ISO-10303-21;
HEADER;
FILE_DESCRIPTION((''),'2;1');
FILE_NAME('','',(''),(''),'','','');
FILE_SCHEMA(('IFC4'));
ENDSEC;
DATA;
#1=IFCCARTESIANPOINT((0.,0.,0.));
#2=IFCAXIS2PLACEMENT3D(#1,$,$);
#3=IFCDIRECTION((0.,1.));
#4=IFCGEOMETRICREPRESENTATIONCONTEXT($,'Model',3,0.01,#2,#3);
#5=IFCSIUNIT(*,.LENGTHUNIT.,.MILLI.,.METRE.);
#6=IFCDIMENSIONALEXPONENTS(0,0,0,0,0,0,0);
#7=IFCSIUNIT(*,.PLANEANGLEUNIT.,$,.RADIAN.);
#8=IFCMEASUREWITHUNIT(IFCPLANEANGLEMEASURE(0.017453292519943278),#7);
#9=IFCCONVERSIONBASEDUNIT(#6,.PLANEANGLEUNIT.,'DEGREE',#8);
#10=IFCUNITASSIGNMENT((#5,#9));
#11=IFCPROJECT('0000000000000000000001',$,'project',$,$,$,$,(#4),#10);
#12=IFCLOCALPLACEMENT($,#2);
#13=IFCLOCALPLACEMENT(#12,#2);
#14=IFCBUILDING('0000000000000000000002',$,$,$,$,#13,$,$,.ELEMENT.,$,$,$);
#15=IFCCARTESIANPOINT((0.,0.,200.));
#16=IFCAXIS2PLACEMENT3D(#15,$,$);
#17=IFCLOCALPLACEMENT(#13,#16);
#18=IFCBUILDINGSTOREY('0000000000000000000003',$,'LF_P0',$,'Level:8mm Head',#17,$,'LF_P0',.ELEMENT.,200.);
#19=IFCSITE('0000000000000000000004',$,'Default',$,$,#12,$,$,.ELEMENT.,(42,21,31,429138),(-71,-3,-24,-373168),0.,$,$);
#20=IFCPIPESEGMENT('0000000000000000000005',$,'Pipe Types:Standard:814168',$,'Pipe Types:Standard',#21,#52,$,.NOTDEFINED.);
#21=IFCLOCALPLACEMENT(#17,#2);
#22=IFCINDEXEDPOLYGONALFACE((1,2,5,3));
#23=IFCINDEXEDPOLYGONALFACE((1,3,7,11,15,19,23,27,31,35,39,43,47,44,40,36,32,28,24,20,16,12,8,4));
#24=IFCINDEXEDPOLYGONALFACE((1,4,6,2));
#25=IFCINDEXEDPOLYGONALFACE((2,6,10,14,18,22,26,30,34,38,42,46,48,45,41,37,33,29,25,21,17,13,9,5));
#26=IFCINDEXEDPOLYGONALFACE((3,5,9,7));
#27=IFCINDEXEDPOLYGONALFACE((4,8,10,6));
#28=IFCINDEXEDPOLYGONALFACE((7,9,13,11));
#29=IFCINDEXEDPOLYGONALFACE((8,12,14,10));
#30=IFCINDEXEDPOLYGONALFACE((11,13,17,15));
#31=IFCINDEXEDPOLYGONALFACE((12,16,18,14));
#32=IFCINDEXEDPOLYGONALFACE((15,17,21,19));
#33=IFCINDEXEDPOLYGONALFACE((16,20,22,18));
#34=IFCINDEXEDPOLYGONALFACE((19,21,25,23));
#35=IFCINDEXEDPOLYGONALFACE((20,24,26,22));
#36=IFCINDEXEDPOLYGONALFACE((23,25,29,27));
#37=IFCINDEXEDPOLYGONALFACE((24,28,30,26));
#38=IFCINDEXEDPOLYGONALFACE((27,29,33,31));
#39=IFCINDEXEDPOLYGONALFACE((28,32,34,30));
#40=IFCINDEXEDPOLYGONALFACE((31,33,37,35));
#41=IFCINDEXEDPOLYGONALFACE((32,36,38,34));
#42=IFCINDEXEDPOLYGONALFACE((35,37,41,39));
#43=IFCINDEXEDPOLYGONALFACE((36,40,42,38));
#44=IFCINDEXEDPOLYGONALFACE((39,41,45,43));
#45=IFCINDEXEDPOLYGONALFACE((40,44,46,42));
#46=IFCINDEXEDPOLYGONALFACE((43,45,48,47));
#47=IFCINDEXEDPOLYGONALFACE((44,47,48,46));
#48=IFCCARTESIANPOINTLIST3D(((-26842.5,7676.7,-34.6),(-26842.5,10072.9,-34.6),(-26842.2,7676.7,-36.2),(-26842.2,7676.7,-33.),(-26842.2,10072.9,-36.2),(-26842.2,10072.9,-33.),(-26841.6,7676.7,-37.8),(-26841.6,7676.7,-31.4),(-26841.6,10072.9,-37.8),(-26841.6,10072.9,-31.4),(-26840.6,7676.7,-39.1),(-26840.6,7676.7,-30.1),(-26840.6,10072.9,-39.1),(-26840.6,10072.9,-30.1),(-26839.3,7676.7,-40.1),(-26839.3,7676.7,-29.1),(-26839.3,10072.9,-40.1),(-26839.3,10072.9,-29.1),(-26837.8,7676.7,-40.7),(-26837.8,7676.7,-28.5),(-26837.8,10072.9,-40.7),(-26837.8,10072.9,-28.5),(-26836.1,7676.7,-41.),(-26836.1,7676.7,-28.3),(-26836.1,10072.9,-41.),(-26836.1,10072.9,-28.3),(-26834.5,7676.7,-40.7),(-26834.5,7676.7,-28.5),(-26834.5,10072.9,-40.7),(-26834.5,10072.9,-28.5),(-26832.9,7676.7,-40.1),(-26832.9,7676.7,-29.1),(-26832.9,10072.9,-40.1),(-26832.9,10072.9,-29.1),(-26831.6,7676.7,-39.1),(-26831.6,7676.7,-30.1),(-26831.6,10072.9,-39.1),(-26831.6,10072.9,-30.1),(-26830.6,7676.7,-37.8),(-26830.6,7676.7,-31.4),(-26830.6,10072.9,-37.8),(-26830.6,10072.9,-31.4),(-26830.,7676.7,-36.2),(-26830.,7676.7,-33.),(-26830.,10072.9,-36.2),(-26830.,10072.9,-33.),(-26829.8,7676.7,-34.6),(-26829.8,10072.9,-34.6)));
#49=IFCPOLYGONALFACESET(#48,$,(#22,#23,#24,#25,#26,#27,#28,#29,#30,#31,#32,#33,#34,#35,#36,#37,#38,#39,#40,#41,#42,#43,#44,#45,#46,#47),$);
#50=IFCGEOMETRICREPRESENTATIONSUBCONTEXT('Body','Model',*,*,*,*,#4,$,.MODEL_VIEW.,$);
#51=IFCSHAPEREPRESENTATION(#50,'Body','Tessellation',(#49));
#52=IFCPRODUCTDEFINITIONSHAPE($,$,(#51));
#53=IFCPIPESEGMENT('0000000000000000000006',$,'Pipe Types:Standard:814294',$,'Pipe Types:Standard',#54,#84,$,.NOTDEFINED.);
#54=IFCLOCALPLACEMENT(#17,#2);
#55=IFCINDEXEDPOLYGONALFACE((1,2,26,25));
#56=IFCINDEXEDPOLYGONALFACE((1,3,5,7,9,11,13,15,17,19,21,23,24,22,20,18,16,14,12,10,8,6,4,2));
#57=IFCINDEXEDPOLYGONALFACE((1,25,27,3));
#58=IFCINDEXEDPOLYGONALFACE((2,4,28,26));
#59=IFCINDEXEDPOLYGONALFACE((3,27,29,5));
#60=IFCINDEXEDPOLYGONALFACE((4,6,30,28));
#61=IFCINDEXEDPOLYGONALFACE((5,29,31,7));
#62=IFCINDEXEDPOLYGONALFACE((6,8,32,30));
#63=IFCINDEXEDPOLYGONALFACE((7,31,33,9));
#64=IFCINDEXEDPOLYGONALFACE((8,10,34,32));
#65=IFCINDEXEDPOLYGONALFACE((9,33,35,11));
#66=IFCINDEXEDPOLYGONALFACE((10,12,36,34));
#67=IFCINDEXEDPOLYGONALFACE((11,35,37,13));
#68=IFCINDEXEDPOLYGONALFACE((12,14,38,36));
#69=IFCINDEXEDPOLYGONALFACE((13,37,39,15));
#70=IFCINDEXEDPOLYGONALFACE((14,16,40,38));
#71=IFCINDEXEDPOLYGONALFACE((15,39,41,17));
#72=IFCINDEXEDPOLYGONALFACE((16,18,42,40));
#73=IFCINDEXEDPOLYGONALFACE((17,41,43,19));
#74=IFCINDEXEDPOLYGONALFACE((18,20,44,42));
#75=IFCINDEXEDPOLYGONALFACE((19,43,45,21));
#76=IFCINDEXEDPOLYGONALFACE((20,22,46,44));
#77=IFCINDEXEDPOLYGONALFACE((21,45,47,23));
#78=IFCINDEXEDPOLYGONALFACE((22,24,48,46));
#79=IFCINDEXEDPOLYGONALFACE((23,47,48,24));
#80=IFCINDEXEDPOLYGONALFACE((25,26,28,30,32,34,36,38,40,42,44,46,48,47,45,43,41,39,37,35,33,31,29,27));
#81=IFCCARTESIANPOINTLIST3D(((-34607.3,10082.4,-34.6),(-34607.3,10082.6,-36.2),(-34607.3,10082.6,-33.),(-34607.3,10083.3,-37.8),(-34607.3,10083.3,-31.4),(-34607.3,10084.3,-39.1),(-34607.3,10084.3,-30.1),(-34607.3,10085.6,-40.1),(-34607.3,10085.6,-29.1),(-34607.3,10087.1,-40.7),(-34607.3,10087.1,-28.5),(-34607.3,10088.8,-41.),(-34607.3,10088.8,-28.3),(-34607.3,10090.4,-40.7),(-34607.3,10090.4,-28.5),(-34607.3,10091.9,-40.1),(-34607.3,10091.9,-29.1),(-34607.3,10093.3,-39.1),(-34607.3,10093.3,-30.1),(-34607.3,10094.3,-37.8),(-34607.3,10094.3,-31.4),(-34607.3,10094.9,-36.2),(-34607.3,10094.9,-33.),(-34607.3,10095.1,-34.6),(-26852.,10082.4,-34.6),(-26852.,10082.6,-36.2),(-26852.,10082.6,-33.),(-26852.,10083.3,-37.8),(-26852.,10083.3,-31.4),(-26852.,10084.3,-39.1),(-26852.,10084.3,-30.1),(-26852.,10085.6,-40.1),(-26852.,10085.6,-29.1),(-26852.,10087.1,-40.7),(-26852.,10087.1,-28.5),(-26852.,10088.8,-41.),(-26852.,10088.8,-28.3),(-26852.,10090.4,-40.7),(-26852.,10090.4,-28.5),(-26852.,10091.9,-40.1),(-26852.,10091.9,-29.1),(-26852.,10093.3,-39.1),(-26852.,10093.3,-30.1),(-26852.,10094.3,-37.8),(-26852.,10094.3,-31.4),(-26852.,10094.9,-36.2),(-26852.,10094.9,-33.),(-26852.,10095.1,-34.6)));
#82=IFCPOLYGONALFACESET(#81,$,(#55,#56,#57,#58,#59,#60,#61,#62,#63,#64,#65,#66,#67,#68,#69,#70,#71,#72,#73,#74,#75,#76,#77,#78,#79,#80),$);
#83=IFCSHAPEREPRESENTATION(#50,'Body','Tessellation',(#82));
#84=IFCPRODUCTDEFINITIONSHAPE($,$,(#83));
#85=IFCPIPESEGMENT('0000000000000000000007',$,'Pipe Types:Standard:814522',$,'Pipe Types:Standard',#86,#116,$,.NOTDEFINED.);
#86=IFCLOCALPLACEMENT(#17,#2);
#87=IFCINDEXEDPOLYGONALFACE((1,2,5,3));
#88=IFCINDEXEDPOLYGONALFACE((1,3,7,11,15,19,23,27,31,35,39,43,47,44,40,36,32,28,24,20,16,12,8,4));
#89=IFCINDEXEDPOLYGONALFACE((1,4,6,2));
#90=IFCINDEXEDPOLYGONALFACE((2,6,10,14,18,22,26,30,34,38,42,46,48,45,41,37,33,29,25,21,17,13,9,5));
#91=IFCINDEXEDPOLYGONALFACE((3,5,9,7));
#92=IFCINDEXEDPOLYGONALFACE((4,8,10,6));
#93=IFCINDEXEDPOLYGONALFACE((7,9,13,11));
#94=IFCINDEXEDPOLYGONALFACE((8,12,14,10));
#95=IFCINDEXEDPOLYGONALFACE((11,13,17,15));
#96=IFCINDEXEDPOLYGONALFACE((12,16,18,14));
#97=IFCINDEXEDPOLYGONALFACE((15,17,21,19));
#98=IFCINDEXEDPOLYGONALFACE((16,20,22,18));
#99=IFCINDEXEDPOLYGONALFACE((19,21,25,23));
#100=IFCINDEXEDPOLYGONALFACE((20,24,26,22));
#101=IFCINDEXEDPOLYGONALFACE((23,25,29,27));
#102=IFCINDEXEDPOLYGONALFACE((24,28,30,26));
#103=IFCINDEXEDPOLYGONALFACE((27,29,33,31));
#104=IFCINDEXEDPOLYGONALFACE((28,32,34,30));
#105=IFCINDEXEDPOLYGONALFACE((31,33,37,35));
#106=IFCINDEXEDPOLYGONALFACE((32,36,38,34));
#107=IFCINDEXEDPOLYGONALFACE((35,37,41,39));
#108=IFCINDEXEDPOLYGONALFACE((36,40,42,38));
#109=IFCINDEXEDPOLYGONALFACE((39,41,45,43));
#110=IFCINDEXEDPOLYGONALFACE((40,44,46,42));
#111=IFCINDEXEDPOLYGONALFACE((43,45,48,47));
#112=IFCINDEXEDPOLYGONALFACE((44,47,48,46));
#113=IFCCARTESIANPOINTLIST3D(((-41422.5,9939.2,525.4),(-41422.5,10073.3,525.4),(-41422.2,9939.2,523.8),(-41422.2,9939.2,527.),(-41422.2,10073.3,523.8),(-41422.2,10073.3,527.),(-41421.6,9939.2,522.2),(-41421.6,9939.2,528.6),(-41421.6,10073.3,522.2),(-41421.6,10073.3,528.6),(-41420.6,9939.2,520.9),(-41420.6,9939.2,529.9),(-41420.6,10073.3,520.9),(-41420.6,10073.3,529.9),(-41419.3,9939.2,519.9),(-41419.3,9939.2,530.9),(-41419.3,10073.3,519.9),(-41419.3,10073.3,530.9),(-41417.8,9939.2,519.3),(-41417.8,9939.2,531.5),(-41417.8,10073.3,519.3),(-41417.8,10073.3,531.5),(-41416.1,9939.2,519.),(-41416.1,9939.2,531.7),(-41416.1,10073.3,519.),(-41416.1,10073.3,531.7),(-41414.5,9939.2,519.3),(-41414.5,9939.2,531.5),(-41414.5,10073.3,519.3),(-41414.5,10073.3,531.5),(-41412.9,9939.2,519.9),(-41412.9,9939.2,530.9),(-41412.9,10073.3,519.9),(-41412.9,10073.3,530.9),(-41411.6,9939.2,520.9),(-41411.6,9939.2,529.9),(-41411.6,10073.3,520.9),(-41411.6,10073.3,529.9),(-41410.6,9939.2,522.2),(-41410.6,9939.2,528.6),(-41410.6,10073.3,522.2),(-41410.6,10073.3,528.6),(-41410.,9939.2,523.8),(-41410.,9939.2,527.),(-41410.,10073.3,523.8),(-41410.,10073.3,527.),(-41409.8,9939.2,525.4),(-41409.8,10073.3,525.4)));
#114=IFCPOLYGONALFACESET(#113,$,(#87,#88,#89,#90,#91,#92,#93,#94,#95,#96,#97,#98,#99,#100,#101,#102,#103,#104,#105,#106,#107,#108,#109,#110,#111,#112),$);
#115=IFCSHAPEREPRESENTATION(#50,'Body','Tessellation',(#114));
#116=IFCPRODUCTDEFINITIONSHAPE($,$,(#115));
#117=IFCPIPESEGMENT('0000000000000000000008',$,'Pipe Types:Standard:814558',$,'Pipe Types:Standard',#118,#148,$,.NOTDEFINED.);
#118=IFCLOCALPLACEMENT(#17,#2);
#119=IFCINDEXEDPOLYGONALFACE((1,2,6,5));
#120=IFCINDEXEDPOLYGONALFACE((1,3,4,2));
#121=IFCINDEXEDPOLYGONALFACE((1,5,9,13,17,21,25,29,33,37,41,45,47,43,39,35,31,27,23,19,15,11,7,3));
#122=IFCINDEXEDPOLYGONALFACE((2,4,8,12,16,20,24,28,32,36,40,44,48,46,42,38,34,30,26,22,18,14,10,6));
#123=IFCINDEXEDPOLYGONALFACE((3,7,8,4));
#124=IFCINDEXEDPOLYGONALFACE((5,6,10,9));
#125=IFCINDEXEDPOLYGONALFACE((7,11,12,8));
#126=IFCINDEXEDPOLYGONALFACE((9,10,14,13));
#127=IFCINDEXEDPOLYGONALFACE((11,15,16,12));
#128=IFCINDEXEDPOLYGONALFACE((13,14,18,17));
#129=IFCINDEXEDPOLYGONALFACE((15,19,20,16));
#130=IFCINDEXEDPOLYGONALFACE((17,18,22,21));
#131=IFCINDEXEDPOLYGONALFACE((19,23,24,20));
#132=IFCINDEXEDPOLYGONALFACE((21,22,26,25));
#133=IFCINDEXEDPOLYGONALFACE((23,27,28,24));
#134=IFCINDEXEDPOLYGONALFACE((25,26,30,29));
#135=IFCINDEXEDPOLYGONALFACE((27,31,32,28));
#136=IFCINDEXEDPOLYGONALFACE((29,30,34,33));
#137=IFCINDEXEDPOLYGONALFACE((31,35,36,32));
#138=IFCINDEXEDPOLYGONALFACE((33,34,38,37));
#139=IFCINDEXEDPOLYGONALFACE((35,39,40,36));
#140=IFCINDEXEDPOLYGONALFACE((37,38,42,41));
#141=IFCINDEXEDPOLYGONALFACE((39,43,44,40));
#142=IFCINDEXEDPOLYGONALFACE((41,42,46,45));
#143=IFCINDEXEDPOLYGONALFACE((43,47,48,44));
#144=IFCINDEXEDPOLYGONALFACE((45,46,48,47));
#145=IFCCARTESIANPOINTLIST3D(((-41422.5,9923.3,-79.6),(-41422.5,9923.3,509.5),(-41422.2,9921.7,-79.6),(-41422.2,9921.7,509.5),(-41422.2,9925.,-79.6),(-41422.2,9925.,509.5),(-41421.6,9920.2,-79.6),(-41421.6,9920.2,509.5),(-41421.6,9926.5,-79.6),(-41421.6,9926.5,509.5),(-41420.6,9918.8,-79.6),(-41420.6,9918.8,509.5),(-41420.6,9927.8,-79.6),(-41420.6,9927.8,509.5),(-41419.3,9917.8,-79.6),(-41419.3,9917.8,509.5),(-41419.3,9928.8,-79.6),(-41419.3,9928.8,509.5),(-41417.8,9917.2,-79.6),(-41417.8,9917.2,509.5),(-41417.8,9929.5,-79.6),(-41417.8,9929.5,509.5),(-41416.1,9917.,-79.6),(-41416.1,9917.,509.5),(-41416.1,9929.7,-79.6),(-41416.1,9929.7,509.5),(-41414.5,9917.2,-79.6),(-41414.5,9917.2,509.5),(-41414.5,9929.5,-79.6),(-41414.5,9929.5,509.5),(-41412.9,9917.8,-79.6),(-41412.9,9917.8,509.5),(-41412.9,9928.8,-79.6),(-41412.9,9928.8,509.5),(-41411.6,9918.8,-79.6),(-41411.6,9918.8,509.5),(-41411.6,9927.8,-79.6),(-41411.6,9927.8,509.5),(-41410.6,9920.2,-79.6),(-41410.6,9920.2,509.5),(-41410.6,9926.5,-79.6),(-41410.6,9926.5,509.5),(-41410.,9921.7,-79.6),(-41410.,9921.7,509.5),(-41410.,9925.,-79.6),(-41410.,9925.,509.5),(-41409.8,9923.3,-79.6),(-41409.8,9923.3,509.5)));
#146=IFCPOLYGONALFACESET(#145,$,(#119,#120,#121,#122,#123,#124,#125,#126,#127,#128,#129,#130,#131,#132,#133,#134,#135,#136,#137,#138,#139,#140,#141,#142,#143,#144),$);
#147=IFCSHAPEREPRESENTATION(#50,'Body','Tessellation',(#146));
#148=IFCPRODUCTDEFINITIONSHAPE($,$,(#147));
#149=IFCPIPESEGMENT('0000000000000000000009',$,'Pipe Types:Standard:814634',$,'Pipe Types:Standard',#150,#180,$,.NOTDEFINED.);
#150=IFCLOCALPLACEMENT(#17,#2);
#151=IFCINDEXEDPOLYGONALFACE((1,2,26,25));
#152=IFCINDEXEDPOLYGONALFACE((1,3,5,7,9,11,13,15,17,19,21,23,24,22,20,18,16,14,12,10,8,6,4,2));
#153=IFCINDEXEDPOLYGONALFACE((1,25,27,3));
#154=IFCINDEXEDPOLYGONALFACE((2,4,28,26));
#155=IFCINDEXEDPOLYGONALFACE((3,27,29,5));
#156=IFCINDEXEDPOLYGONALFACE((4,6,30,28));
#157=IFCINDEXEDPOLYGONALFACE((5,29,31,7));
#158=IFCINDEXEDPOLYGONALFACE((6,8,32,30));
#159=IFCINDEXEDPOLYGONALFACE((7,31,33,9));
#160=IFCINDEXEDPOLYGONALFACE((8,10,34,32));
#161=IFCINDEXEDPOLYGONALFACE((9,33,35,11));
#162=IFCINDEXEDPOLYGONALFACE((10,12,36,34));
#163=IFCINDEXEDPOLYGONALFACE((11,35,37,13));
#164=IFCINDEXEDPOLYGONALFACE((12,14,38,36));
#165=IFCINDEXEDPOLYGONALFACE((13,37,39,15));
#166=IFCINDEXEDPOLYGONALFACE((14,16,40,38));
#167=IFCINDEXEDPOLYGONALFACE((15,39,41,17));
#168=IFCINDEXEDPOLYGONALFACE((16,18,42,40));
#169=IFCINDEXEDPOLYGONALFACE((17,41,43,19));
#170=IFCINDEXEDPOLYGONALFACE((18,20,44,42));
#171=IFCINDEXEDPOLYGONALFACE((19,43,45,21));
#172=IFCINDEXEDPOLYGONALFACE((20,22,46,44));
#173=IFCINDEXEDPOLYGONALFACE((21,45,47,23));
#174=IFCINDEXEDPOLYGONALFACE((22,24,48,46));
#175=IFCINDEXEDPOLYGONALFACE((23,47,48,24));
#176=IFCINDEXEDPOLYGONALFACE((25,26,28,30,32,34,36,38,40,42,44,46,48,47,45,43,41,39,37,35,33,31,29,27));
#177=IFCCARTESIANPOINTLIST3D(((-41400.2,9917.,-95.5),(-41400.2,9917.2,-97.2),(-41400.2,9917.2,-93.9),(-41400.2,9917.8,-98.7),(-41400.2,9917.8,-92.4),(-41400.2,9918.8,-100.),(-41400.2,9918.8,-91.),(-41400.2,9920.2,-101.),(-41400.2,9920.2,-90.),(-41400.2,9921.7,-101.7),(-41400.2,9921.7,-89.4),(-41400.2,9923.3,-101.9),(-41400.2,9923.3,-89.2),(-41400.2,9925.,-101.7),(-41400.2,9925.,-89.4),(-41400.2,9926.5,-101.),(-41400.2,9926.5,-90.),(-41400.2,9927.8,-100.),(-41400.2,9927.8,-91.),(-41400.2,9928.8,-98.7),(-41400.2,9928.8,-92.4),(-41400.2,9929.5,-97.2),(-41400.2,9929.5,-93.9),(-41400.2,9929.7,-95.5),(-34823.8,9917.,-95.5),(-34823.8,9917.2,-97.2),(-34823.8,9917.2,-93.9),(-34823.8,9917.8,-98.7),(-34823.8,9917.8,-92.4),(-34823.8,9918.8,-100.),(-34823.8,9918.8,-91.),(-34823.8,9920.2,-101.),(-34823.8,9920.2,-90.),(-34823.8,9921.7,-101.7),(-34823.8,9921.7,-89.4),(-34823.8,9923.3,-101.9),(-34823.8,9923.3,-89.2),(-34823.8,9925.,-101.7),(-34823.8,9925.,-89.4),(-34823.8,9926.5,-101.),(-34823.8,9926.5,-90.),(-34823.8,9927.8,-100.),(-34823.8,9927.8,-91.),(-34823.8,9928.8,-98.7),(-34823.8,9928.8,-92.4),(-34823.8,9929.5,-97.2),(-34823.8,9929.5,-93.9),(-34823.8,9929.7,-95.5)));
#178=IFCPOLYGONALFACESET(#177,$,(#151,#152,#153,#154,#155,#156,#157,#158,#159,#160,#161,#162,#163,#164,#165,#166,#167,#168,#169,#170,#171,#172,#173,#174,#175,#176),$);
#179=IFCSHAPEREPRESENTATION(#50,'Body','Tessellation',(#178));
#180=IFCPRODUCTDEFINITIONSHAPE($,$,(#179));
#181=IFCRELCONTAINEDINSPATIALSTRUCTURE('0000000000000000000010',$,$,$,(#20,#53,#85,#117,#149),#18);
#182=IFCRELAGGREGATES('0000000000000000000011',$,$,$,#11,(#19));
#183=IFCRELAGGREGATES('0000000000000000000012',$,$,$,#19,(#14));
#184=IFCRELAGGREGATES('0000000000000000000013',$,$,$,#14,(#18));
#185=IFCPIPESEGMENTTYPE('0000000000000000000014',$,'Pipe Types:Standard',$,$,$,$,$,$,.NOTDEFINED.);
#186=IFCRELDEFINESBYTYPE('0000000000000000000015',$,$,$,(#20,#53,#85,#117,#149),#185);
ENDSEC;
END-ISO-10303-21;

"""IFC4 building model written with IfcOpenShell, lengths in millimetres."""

from ifc_helpers import new_model, entity, si_unit, converted_unit, direction, frame, origin, place, context, subcontext, project, spatial, arc, indexed_curve, outline, extrude, type_object, element, save


model = new_model("IFC4")

# Units and contexts
model_context = context("Model", 3, precision=0.01, world=origin(), true_north=direction((0.0, 1.0)))
body_context = subcontext(model_context, "Body", "Model", "MODEL_VIEW")
ifc_project = project(units=[si_unit("LENGTHUNIT", "METRE", prefix="MILLI"), converted_unit("PLANEANGLEUNIT", "DEGREE", entity("IfcPlaneAngleMeasure", 0.017453292519943278), si_unit("PLANEANGLEUNIT", "RADIAN"), dimensions=[0, 0, 0, 0, 0, 0, 0])], contexts=[model_context])

# Site, building, storey
site_placement = place(None, origin())
site = spatial("IfcSite", under=ifc_project, at=site_placement, Name="Default", CompositionType="ELEMENT", RefLatitude=(42, 21, 31, 429138), RefLongitude=(-71, -3, -24, -373168), RefElevation=0.0)
building_placement = place(site_placement, origin())
building = spatial("IfcBuilding", under=site, at=building_placement, CompositionType="ELEMENT")
storey_placement = place(building_placement, frame((0.0, 0.0, 200.0)))
storey = spatial("IfcBuildingStorey", under=building, at=storey_placement, Name="LF_P0", ObjectType="Level:8mm Head", LongName="LF_P0", CompositionType="ELEMENT", Elevation=200.0)

# Pipe segments
pipe_segment_type = type_object("IfcPipeSegmentType", Name="Pipe Types:Standard", PredefinedType="NOTDEFINED")
pipe_segment_1_placement = place(storey_placement, origin())
element("IfcPipeSegment", 1, at=pipe_segment_1_placement, inside=storey, type_object=pipe_segment_type, Name="Pipe Types:Standard:814168", ObjectType="Pipe Types:Standard", PredefinedType="NOTDEFINED", context=body_context, shape_type="SweptSolid", body=[
    extrude(outline(indexed_curve([(6.3, 0.0), (4.5, 4.5), (0.0, 6.4), (-4.5, 4.5), (-6.3, 0.0), (-4.5, -4.5), (0.0, -6.3), (4.5, -4.5)], segments=[arc(1, 2, 3), arc(3, 4, 5), arc(5, 6, 7), arc(7, 8, 1)], self_intersect=False)), frame((-26836.1, 7676.7, -34.6), z_axis=(0.0, 1.0, 0.0), x_axis=(1.0, 0.0, 0.0)), (0.0, 0.0, 1.0), 2396.1),
])
pipe_segment_2_placement = place(storey_placement, origin())
element("IfcPipeSegment", 2, at=pipe_segment_2_placement, inside=storey, type_object=pipe_segment_type, Name="Pipe Types:Standard:814294", ObjectType="Pipe Types:Standard", PredefinedType="NOTDEFINED", context=body_context, shape_type="SweptSolid", body=[
    extrude(outline(indexed_curve([(6.4, 0.0), (4.5, 4.5), (0.0, 6.4), (-4.5, 4.5), (-6.3, 0.0), (-4.5, -4.5), (0.0, -6.4), (4.5, -4.5)], segments=[arc(1, 2, 3), arc(3, 4, 5), arc(5, 6, 7), arc(7, 8, 1)], self_intersect=False)), frame((-34607.3, 10088.8, -34.6), z_axis=(1.0, 0.0, 0.0), x_axis=(0.0, 1.0, 0.0)), (0.0, 0.0, 1.0), 7755.3),
])
pipe_segment_3_placement = place(storey_placement, origin())
element("IfcPipeSegment", 3, at=pipe_segment_3_placement, inside=storey, type_object=pipe_segment_type, Name="Pipe Types:Standard:814522", ObjectType="Pipe Types:Standard", PredefinedType="NOTDEFINED", context=body_context, shape_type="SweptSolid", body=[
    extrude(outline(indexed_curve([(6.4, 0.0), (4.5, 4.5), (0.0, 6.4), (-4.5, 4.5), (-6.4, 0.0), (-4.5, -4.5), (0.0, -6.4), (4.5, -4.5)], segments=[arc(1, 2, 3), arc(3, 4, 5), arc(5, 6, 7), arc(7, 8, 1)], self_intersect=False)), frame((-41416.1, 9939.2, 525.4), z_axis=(0.0, 1.0, 0.0), x_axis=(-1.0, 0.0, 0.0)), (0.0, 0.0, 1.0), 134.1),
])
pipe_segment_4_placement = place(storey_placement, origin())
element("IfcPipeSegment", 4, at=pipe_segment_4_placement, inside=storey, type_object=pipe_segment_type, Name="Pipe Types:Standard:814558", ObjectType="Pipe Types:Standard", PredefinedType="NOTDEFINED", context=body_context, shape_type="SweptSolid", body=[
    extrude(outline(indexed_curve([(6.4, 0.0), (4.5, 4.5), (0.0, 6.4), (-4.5, 4.5), (-6.4, 0.0), (-4.5, -4.5), (0.0, -6.4), (4.5, -4.5)], segments=[arc(1, 2, 3), arc(3, 4, 5), arc(5, 6, 7), arc(7, 8, 1)], self_intersect=False)), frame((-41416.1, 9923.3, -79.6)), (0.0, 0.0, 1.0), 589.1),
])
pipe_segment_5_placement = place(storey_placement, origin())
element("IfcPipeSegment", 5, at=pipe_segment_5_placement, inside=storey, type_object=pipe_segment_type, Name="Pipe Types:Standard:814634", ObjectType="Pipe Types:Standard", PredefinedType="NOTDEFINED", context=body_context, shape_type="SweptSolid", body=[
    extrude(outline(indexed_curve([(6.4, 0.0), (4.5, 4.5), (0.0, 6.3), (-4.5, 4.5), (-6.4, 0.0), (-4.5, -4.5), (0.0, -6.3), (4.5, -4.5)], segments=[arc(1, 2, 3), arc(3, 4, 5), arc(5, 6, 7), arc(7, 8, 1)], self_intersect=False)), frame((-41400.2, 9923.3, -95.5), z_axis=(1.0, 0.0, 0.0), x_axis=(0.0, -1.0, 0.0)), (0.0, 0.0, 1.0), 6576.4),
])

save(model, "model.ifc")
